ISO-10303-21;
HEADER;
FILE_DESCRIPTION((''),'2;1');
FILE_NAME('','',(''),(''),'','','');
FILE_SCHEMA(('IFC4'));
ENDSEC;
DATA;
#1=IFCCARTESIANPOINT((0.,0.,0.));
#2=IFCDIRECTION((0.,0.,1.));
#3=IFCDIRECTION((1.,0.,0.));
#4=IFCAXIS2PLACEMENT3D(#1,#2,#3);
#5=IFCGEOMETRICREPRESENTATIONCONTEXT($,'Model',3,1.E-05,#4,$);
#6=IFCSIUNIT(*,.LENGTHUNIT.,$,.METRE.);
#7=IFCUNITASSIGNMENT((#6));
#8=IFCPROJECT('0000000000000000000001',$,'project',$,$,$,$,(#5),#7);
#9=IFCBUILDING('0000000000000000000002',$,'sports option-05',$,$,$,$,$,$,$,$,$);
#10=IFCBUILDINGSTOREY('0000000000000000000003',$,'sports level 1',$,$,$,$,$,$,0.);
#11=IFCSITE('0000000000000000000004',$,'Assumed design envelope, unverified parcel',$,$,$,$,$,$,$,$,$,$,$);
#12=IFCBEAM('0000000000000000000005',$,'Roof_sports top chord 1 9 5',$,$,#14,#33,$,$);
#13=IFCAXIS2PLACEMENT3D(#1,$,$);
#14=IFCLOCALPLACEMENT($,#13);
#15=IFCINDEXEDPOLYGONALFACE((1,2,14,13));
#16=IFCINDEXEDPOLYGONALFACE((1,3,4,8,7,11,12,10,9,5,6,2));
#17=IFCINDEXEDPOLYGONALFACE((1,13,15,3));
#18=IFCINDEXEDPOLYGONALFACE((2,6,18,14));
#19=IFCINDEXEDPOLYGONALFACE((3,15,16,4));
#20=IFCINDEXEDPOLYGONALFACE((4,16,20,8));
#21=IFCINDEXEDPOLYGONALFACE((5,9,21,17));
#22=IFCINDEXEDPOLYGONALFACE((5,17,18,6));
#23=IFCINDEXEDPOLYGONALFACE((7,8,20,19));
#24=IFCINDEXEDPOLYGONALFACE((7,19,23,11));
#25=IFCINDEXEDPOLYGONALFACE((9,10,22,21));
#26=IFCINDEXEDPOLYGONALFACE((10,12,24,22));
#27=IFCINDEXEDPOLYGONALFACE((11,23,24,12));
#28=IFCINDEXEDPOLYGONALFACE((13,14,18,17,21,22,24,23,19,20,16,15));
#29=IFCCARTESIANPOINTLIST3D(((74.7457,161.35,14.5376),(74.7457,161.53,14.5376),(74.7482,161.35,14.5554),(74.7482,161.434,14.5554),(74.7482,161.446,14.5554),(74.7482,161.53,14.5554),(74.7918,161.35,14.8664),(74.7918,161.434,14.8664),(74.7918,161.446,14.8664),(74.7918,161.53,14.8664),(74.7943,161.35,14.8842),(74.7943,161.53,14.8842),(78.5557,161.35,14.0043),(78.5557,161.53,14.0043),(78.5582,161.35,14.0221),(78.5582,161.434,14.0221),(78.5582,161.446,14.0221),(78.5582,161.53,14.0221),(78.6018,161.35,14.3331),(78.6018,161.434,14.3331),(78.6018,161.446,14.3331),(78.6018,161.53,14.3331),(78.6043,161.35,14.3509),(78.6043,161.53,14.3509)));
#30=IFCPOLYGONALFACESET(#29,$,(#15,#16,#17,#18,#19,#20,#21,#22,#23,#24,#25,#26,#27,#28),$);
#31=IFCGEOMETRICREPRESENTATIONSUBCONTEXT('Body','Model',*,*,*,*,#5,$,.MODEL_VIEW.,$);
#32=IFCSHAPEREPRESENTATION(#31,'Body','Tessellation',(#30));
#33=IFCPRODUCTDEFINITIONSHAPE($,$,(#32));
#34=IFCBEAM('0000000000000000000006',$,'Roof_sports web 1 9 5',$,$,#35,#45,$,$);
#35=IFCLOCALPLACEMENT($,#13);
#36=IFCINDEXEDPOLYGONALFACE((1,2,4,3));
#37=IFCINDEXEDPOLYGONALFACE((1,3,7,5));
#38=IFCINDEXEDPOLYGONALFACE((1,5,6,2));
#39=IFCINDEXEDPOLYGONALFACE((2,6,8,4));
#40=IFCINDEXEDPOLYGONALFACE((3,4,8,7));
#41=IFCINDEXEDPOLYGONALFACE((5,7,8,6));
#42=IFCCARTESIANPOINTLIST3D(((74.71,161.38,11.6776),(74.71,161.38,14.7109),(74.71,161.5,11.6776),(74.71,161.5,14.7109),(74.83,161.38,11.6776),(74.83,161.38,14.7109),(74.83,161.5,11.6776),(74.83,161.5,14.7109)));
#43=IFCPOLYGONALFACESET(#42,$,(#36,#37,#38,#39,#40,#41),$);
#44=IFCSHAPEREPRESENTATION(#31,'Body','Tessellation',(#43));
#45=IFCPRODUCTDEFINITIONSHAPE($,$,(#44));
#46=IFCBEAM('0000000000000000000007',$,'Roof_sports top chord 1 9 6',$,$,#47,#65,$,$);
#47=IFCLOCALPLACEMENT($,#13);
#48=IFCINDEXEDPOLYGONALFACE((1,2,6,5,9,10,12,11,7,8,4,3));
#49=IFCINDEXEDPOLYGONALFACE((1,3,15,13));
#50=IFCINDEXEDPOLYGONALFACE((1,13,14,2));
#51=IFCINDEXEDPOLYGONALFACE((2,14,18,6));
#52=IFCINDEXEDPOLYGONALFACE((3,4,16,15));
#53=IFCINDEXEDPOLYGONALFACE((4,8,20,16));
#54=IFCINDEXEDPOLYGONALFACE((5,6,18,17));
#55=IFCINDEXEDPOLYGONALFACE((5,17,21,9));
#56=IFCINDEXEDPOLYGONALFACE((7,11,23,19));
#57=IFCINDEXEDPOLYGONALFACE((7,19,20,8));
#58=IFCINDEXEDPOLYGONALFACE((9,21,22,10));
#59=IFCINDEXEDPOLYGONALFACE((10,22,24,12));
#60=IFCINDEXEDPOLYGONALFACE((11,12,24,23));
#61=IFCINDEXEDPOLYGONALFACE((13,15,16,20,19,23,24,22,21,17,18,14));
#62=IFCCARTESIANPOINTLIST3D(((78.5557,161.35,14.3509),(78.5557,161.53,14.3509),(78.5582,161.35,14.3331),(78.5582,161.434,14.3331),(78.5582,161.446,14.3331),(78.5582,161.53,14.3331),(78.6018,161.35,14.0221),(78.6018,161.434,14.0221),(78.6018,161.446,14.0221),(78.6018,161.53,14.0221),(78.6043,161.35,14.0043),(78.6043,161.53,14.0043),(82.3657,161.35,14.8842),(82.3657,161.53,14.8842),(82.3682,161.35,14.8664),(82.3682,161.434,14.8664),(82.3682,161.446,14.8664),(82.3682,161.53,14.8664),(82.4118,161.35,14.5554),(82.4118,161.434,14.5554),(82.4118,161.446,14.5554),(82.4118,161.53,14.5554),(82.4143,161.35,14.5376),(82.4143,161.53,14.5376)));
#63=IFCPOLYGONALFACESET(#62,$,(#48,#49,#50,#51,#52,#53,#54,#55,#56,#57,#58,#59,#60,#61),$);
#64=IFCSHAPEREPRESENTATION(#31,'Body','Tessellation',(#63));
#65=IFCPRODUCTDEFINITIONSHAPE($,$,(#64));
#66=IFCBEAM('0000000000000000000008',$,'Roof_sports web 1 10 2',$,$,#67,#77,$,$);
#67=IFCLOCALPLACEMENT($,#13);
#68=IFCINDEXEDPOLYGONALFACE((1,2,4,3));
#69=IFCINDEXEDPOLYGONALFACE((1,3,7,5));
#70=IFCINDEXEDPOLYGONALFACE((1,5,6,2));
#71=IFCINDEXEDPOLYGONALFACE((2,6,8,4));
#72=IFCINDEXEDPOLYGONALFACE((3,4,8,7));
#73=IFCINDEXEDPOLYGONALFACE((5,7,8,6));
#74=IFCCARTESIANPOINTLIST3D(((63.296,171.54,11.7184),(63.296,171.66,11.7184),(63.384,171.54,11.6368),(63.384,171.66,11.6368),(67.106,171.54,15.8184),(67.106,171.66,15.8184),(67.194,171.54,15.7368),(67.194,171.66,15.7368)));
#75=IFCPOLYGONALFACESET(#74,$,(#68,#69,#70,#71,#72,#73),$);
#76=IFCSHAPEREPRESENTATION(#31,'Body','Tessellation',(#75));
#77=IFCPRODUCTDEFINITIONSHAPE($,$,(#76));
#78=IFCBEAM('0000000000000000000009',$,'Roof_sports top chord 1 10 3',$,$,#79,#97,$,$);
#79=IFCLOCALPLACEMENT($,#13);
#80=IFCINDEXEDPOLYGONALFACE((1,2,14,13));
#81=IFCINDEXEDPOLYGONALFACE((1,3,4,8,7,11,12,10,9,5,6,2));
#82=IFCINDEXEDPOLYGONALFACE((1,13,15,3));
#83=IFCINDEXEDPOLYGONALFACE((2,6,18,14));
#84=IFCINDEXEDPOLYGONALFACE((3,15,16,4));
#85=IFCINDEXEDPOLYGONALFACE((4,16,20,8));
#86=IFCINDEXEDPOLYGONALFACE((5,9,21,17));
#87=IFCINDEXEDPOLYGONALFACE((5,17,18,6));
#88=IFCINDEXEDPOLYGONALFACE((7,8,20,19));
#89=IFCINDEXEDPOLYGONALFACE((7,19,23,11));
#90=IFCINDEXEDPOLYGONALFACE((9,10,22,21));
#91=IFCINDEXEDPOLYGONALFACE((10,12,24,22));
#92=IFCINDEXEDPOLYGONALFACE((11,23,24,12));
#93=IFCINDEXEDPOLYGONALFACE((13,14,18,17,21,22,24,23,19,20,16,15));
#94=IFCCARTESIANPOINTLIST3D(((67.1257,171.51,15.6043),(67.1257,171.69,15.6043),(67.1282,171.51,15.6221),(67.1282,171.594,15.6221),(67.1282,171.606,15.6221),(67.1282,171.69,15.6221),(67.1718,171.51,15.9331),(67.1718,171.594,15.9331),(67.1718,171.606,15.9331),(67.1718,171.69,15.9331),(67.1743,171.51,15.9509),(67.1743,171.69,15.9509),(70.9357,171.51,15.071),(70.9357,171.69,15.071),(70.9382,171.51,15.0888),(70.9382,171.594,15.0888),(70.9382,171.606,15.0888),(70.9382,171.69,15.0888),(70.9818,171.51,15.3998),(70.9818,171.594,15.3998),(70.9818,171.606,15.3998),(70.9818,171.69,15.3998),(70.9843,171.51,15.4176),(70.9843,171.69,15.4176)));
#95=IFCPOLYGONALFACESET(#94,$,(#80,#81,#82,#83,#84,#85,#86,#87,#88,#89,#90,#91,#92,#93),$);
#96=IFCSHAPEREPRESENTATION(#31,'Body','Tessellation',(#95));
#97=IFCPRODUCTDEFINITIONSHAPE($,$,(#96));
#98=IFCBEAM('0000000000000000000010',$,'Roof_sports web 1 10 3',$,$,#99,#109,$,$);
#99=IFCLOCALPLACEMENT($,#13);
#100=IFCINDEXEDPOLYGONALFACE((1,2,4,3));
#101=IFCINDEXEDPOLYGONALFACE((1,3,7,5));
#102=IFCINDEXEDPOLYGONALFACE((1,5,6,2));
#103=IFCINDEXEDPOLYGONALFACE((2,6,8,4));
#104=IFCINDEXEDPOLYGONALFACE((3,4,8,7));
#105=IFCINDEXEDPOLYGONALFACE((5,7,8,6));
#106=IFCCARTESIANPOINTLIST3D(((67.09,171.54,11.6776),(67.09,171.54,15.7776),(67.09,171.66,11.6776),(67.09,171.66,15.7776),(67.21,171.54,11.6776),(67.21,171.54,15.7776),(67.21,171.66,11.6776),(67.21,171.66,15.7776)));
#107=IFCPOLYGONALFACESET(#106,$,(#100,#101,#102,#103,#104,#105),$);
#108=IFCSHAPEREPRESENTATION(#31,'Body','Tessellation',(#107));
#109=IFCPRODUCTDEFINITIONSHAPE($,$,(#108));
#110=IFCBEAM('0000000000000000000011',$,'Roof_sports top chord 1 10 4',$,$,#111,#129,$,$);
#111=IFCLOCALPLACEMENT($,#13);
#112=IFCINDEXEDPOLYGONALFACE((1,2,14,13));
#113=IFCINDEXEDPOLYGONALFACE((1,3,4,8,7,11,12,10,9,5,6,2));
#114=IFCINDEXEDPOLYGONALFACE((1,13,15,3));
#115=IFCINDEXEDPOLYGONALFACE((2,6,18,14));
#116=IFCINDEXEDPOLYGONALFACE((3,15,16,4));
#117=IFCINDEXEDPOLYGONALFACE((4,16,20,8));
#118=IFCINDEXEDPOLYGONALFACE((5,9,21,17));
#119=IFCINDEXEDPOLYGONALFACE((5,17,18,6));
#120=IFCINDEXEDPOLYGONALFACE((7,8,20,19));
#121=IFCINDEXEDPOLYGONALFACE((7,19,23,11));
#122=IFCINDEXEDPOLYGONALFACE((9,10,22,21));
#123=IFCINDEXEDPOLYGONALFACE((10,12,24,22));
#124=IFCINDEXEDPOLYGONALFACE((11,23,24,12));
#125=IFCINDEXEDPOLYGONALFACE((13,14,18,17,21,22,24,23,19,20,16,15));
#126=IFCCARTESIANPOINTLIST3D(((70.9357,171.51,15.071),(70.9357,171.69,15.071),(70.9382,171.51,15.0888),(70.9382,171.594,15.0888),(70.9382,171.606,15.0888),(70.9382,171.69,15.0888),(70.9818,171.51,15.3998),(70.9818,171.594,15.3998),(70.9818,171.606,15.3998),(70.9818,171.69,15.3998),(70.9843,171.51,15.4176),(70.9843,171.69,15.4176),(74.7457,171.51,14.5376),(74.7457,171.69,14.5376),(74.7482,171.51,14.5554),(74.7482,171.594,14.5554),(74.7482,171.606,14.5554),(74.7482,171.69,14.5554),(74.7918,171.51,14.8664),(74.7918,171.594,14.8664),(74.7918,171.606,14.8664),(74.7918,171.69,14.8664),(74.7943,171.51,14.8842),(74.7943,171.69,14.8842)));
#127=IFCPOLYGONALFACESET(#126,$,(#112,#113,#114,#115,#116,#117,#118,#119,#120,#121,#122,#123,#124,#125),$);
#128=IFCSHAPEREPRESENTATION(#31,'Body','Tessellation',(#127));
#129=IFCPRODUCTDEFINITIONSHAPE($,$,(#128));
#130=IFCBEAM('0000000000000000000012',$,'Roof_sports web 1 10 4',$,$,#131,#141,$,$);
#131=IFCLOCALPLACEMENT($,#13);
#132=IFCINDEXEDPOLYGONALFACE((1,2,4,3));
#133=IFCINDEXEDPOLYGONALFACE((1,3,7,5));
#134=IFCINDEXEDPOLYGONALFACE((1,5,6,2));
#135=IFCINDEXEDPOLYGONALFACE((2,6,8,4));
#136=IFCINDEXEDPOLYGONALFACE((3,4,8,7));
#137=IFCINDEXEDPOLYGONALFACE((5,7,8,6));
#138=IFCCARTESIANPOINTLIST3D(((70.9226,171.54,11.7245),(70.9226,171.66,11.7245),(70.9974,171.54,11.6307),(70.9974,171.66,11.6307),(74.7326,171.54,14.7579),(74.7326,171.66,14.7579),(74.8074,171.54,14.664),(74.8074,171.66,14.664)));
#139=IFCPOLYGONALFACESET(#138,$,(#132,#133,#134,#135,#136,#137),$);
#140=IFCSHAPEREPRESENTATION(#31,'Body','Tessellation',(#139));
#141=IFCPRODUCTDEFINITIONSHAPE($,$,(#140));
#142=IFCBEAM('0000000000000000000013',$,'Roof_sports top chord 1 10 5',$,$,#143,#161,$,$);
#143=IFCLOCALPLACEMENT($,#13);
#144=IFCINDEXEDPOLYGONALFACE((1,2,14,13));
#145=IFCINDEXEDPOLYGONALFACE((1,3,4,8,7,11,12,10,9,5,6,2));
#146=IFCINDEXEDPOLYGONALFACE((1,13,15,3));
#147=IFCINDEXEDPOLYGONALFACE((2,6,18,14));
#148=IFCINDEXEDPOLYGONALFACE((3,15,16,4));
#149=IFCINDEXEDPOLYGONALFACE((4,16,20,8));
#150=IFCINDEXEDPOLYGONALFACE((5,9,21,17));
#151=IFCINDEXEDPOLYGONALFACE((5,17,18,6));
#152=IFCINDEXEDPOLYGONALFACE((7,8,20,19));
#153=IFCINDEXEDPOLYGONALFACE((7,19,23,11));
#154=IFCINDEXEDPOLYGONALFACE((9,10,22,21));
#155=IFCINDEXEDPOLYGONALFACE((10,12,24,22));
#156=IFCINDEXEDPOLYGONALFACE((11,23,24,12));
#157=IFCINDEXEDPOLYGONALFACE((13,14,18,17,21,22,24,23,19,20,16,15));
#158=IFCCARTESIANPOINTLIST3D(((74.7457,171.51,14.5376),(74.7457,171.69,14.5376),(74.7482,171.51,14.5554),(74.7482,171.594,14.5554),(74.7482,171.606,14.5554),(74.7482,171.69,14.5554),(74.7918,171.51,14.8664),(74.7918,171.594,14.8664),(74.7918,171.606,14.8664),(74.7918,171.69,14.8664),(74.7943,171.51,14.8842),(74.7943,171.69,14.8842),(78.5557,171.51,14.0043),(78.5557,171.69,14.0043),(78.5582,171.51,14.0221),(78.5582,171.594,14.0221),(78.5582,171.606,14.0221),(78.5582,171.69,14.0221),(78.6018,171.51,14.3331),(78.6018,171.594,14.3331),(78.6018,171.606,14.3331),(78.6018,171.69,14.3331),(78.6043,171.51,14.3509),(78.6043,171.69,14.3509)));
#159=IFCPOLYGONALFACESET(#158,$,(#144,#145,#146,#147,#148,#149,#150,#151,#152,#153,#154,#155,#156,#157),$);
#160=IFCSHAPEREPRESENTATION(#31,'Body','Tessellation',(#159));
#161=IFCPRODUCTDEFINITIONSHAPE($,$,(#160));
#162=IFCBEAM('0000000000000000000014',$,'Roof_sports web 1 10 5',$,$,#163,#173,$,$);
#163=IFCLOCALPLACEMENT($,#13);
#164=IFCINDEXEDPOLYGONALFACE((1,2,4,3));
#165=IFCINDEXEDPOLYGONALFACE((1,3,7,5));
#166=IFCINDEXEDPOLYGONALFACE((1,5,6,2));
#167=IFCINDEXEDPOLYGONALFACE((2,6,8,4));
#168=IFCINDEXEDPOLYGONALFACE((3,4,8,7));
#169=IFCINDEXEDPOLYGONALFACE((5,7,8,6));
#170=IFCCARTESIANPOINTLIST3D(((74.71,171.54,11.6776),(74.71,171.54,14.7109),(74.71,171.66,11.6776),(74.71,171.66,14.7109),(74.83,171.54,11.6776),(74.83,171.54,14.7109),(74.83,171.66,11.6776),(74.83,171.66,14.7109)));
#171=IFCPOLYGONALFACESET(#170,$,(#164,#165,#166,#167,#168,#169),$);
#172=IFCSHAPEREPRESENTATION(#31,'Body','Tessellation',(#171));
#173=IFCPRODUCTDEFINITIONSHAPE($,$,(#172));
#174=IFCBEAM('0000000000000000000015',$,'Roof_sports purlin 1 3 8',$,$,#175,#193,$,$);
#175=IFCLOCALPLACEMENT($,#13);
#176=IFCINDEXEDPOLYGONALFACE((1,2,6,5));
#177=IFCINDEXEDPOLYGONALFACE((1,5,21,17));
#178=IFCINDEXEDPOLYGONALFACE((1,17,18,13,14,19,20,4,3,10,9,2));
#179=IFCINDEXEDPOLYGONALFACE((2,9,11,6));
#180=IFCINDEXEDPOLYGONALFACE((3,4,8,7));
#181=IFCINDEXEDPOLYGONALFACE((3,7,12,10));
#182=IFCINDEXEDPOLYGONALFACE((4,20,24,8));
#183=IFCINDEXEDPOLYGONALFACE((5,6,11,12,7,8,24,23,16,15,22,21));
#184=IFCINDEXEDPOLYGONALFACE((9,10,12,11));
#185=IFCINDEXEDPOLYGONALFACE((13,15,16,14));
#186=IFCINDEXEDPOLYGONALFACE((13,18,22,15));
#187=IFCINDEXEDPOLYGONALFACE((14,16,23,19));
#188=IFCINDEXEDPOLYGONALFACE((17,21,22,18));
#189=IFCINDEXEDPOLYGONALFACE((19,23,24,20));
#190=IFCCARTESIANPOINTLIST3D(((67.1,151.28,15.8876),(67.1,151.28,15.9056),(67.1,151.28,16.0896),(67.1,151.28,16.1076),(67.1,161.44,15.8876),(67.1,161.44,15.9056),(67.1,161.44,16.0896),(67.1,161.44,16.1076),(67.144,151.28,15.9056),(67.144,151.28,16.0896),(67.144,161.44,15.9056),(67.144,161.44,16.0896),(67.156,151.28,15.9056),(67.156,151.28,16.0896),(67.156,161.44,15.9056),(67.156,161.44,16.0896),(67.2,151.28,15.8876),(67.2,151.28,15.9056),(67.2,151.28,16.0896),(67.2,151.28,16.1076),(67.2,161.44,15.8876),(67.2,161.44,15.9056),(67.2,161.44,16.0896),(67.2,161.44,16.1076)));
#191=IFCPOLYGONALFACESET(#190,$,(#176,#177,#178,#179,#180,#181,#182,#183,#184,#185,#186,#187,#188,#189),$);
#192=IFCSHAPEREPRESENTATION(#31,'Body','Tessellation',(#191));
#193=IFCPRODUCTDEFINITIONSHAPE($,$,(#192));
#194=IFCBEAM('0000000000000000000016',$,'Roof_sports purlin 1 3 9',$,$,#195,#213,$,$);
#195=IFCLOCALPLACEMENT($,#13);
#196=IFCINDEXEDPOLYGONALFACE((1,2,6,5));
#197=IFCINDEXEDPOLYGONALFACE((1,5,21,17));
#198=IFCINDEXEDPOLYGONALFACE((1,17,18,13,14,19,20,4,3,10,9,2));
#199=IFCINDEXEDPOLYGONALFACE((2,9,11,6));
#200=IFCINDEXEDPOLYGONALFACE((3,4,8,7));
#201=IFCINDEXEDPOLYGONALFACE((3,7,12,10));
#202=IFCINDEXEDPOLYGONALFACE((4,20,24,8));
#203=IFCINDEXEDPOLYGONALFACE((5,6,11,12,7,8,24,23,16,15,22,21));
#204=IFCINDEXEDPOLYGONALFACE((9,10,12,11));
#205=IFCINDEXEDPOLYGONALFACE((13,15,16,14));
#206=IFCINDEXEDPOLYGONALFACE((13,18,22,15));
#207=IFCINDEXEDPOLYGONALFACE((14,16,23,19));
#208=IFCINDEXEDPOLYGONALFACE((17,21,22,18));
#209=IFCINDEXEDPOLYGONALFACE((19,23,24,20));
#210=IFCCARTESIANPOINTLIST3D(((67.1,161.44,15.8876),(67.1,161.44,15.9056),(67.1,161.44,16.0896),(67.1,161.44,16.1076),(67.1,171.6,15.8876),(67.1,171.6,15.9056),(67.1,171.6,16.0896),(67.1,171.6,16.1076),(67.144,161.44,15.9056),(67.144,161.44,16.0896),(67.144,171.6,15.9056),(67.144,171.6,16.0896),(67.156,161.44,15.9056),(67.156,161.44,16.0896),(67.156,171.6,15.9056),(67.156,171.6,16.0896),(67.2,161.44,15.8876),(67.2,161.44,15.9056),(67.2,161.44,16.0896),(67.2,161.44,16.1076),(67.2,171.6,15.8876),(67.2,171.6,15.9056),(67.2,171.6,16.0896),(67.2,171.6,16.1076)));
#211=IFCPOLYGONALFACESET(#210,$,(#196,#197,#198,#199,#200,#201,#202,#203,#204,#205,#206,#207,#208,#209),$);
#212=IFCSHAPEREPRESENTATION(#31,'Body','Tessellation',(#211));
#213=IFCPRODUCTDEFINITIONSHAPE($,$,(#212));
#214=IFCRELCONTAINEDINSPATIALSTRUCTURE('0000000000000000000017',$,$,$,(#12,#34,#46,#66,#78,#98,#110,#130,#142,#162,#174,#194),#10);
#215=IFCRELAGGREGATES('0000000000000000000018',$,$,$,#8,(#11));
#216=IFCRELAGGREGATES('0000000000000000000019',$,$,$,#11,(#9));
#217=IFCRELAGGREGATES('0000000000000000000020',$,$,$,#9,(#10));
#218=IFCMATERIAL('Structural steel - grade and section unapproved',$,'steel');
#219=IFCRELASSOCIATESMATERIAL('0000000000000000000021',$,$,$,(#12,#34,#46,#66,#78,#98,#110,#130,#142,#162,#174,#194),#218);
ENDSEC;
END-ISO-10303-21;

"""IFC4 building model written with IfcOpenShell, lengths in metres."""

from ifc_helpers import new_model, si_unit, frame, origin_with_axes, place, context, subcontext, project, spatial, rectangle, i_section, extrude, material, element, save


model = new_model("IFC4")

# Units and contexts
model_context = context("Model", 3, precision=1e-05, world=origin_with_axes())
body_context = subcontext(model_context, "Body", "Model", "MODEL_VIEW")
ifc_project = project(units=[si_unit("LENGTHUNIT", "METRE")], contexts=[model_context])

# Site, building, storey
site = spatial("IfcSite", under=ifc_project, Name="Assumed design envelope, unverified parcel")
building = spatial("IfcBuilding", under=site, Name="sports option-05")
storey = spatial("IfcBuildingStorey", under=building, Name="sports level 1", Elevation=0.0)

# Beams
ifc_material = material(Name="Structural steel - grade and section unapproved", Category="steel")
beam_1_placement = place(None, frame((74.77, 161.44, 14.7109), z_axis=(0.990344, 0.0, -0.138631), x_axis=(0.0, 1.0, 0.0)))
element("IfcBeam", 1, at=beam_1_placement, inside=storey, material=ifc_material, Name="Roof_sports top chord 1 9 5", context=body_context, shape_type="SweptSolid", body=[
    extrude(i_section(OverallWidth=0.18, OverallDepth=0.35, WebThickness=0.012, FlangeThickness=0.018, FilletRadius=0.0), origin_with_axes(), (0.0, 0.0, 1.0), 3.8472),
])
beam_2_placement = place(None, frame((74.77, 161.44, 11.6776), z_axis=(0.0, 0.0, 1.0), x_axis=(-1.0, 0.0, 0.0)))
element("IfcBeam", 2, at=beam_2_placement, inside=storey, material=ifc_material, Name="Roof_sports web 1 9 5", context=body_context, shape_type="SweptSolid", body=[
    extrude(rectangle(XDim=0.12, YDim=0.12), origin_with_axes(), (0.0, 0.0, 1.0), 3.0333),
])
beam_3_placement = place(None, frame((78.58, 161.44, 14.1776), z_axis=(0.990344, 0.0, 0.138631), x_axis=(0.0, 1.0, 0.0)))
element("IfcBeam", 3, at=beam_3_placement, inside=storey, material=ifc_material, Name="Roof_sports top chord 1 9 6", context=body_context, shape_type="SweptSolid", body=[
    extrude(i_section(OverallWidth=0.18, OverallDepth=0.35, WebThickness=0.012, FlangeThickness=0.018, FilletRadius=0.0), origin_with_axes(), (0.0, 0.0, 1.0), 3.8471),
])
beam_4_placement = place(None, frame((63.34, 171.6, 11.6776), z_axis=(0.680725, 0.0, 0.732539), x_axis=(0.0, 1.0, 0.0)))
element("IfcBeam", 4, at=beam_4_placement, inside=storey, material=ifc_material, Name="Roof_sports web 1 10 2", context=body_context, shape_type="SweptSolid", body=[
    extrude(rectangle(XDim=0.12, YDim=0.12), origin_with_axes(), (0.0, 0.0, 1.0), 5.597),
])
beam_5_placement = place(None, frame((67.15, 171.6, 15.7776), z_axis=(0.990344, 0.0, -0.138631), x_axis=(0.0, 1.0, 0.0)))
element("IfcBeam", 5, at=beam_5_placement, inside=storey, material=ifc_material, Name="Roof_sports top chord 1 10 3", context=body_context, shape_type="SweptSolid", body=[
    extrude(i_section(OverallWidth=0.18, OverallDepth=0.35, WebThickness=0.012, FlangeThickness=0.018, FilletRadius=0.0), origin_with_axes(), (0.0, 0.0, 1.0), 3.8471),
])
beam_6_placement = place(None, frame((67.15, 171.6, 11.6776), z_axis=(0.0, 0.0, 1.0), x_axis=(-1.0, 0.0, 0.0)))
element("IfcBeam", 6, at=beam_6_placement, inside=storey, material=ifc_material, Name="Roof_sports web 1 10 3", context=body_context, shape_type="SweptSolid", body=[
    extrude(rectangle(XDim=0.12, YDim=0.12), origin_with_axes(), (0.0, 0.0, 1.0), 4.1),
])
beam_7_placement = place(None, frame((70.96, 171.6, 15.2443), z_axis=(0.990344, 0.0, -0.138631), x_axis=(0.0, 1.0, 0.0)))
element("IfcBeam", 7, at=beam_7_placement, inside=storey, material=ifc_material, Name="Roof_sports top chord 1 10 4", context=body_context, shape_type="SweptSolid", body=[
    extrude(i_section(OverallWidth=0.18, OverallDepth=0.35, WebThickness=0.012, FlangeThickness=0.018, FilletRadius=0.0), origin_with_axes(), (0.0, 0.0, 1.0), 3.8471),
])
beam_8_placement = place(None, frame((70.96, 171.6, 11.6776), z_axis=(0.782336, 0.0, 0.622857), x_axis=(0.0, 1.0, 0.0)))
element("IfcBeam", 8, at=beam_8_placement, inside=storey, material=ifc_material, Name="Roof_sports web 1 10 4", context=body_context, shape_type="SweptSolid", body=[
    extrude(rectangle(XDim=0.12, YDim=0.12), origin_with_axes(), (0.0, 0.0, 1.0), 4.87),
])
beam_9_placement = place(None, frame((74.77, 171.6, 14.7109), z_axis=(0.990344, 0.0, -0.138631), x_axis=(0.0, 1.0, 0.0)))
element("IfcBeam", 9, at=beam_9_placement, inside=storey, material=ifc_material, Name="Roof_sports top chord 1 10 5", context=body_context, shape_type="SweptSolid", body=[
    extrude(i_section(OverallWidth=0.18, OverallDepth=0.35, WebThickness=0.012, FlangeThickness=0.018, FilletRadius=0.0), origin_with_axes(), (0.0, 0.0, 1.0), 3.8472),
])
beam_10_placement = place(None, frame((74.77, 171.6, 11.6776), z_axis=(0.0, 0.0, 1.0), x_axis=(-1.0, 0.0, 0.0)))
element("IfcBeam", 10, at=beam_10_placement, inside=storey, material=ifc_material, Name="Roof_sports web 1 10 5", context=body_context, shape_type="SweptSolid", body=[
    extrude(rectangle(XDim=0.12, YDim=0.12), origin_with_axes(), (0.0, 0.0, 1.0), 3.0333),
])
for number, where, z_axis, x_axis, name in (
    (11, (67.15, 151.28, 15.9976), (0.0, 1.0, 0.0), (-1.0, 0.0, 0.0), "Roof_sports purlin 1 3 8"),
    (12, (67.15, 161.44, 15.9976), (0.0, 1.0, 0.0), (-1.0, 0.0, 0.0), "Roof_sports purlin 1 3 9"),
):
    element("IfcBeam", number, at=place(None, frame(where, z_axis=z_axis, x_axis=x_axis)), inside=storey, material=ifc_material, Name=name, context=body_context, shape_type="SweptSolid", body=[
        extrude(i_section(OverallWidth=0.1, OverallDepth=0.22, WebThickness=0.012, FlangeThickness=0.018, FilletRadius=0.0), origin_with_axes(), (0.0, 0.0, 1.0), 10.16),
    ])

save(model, "model.ifc")
